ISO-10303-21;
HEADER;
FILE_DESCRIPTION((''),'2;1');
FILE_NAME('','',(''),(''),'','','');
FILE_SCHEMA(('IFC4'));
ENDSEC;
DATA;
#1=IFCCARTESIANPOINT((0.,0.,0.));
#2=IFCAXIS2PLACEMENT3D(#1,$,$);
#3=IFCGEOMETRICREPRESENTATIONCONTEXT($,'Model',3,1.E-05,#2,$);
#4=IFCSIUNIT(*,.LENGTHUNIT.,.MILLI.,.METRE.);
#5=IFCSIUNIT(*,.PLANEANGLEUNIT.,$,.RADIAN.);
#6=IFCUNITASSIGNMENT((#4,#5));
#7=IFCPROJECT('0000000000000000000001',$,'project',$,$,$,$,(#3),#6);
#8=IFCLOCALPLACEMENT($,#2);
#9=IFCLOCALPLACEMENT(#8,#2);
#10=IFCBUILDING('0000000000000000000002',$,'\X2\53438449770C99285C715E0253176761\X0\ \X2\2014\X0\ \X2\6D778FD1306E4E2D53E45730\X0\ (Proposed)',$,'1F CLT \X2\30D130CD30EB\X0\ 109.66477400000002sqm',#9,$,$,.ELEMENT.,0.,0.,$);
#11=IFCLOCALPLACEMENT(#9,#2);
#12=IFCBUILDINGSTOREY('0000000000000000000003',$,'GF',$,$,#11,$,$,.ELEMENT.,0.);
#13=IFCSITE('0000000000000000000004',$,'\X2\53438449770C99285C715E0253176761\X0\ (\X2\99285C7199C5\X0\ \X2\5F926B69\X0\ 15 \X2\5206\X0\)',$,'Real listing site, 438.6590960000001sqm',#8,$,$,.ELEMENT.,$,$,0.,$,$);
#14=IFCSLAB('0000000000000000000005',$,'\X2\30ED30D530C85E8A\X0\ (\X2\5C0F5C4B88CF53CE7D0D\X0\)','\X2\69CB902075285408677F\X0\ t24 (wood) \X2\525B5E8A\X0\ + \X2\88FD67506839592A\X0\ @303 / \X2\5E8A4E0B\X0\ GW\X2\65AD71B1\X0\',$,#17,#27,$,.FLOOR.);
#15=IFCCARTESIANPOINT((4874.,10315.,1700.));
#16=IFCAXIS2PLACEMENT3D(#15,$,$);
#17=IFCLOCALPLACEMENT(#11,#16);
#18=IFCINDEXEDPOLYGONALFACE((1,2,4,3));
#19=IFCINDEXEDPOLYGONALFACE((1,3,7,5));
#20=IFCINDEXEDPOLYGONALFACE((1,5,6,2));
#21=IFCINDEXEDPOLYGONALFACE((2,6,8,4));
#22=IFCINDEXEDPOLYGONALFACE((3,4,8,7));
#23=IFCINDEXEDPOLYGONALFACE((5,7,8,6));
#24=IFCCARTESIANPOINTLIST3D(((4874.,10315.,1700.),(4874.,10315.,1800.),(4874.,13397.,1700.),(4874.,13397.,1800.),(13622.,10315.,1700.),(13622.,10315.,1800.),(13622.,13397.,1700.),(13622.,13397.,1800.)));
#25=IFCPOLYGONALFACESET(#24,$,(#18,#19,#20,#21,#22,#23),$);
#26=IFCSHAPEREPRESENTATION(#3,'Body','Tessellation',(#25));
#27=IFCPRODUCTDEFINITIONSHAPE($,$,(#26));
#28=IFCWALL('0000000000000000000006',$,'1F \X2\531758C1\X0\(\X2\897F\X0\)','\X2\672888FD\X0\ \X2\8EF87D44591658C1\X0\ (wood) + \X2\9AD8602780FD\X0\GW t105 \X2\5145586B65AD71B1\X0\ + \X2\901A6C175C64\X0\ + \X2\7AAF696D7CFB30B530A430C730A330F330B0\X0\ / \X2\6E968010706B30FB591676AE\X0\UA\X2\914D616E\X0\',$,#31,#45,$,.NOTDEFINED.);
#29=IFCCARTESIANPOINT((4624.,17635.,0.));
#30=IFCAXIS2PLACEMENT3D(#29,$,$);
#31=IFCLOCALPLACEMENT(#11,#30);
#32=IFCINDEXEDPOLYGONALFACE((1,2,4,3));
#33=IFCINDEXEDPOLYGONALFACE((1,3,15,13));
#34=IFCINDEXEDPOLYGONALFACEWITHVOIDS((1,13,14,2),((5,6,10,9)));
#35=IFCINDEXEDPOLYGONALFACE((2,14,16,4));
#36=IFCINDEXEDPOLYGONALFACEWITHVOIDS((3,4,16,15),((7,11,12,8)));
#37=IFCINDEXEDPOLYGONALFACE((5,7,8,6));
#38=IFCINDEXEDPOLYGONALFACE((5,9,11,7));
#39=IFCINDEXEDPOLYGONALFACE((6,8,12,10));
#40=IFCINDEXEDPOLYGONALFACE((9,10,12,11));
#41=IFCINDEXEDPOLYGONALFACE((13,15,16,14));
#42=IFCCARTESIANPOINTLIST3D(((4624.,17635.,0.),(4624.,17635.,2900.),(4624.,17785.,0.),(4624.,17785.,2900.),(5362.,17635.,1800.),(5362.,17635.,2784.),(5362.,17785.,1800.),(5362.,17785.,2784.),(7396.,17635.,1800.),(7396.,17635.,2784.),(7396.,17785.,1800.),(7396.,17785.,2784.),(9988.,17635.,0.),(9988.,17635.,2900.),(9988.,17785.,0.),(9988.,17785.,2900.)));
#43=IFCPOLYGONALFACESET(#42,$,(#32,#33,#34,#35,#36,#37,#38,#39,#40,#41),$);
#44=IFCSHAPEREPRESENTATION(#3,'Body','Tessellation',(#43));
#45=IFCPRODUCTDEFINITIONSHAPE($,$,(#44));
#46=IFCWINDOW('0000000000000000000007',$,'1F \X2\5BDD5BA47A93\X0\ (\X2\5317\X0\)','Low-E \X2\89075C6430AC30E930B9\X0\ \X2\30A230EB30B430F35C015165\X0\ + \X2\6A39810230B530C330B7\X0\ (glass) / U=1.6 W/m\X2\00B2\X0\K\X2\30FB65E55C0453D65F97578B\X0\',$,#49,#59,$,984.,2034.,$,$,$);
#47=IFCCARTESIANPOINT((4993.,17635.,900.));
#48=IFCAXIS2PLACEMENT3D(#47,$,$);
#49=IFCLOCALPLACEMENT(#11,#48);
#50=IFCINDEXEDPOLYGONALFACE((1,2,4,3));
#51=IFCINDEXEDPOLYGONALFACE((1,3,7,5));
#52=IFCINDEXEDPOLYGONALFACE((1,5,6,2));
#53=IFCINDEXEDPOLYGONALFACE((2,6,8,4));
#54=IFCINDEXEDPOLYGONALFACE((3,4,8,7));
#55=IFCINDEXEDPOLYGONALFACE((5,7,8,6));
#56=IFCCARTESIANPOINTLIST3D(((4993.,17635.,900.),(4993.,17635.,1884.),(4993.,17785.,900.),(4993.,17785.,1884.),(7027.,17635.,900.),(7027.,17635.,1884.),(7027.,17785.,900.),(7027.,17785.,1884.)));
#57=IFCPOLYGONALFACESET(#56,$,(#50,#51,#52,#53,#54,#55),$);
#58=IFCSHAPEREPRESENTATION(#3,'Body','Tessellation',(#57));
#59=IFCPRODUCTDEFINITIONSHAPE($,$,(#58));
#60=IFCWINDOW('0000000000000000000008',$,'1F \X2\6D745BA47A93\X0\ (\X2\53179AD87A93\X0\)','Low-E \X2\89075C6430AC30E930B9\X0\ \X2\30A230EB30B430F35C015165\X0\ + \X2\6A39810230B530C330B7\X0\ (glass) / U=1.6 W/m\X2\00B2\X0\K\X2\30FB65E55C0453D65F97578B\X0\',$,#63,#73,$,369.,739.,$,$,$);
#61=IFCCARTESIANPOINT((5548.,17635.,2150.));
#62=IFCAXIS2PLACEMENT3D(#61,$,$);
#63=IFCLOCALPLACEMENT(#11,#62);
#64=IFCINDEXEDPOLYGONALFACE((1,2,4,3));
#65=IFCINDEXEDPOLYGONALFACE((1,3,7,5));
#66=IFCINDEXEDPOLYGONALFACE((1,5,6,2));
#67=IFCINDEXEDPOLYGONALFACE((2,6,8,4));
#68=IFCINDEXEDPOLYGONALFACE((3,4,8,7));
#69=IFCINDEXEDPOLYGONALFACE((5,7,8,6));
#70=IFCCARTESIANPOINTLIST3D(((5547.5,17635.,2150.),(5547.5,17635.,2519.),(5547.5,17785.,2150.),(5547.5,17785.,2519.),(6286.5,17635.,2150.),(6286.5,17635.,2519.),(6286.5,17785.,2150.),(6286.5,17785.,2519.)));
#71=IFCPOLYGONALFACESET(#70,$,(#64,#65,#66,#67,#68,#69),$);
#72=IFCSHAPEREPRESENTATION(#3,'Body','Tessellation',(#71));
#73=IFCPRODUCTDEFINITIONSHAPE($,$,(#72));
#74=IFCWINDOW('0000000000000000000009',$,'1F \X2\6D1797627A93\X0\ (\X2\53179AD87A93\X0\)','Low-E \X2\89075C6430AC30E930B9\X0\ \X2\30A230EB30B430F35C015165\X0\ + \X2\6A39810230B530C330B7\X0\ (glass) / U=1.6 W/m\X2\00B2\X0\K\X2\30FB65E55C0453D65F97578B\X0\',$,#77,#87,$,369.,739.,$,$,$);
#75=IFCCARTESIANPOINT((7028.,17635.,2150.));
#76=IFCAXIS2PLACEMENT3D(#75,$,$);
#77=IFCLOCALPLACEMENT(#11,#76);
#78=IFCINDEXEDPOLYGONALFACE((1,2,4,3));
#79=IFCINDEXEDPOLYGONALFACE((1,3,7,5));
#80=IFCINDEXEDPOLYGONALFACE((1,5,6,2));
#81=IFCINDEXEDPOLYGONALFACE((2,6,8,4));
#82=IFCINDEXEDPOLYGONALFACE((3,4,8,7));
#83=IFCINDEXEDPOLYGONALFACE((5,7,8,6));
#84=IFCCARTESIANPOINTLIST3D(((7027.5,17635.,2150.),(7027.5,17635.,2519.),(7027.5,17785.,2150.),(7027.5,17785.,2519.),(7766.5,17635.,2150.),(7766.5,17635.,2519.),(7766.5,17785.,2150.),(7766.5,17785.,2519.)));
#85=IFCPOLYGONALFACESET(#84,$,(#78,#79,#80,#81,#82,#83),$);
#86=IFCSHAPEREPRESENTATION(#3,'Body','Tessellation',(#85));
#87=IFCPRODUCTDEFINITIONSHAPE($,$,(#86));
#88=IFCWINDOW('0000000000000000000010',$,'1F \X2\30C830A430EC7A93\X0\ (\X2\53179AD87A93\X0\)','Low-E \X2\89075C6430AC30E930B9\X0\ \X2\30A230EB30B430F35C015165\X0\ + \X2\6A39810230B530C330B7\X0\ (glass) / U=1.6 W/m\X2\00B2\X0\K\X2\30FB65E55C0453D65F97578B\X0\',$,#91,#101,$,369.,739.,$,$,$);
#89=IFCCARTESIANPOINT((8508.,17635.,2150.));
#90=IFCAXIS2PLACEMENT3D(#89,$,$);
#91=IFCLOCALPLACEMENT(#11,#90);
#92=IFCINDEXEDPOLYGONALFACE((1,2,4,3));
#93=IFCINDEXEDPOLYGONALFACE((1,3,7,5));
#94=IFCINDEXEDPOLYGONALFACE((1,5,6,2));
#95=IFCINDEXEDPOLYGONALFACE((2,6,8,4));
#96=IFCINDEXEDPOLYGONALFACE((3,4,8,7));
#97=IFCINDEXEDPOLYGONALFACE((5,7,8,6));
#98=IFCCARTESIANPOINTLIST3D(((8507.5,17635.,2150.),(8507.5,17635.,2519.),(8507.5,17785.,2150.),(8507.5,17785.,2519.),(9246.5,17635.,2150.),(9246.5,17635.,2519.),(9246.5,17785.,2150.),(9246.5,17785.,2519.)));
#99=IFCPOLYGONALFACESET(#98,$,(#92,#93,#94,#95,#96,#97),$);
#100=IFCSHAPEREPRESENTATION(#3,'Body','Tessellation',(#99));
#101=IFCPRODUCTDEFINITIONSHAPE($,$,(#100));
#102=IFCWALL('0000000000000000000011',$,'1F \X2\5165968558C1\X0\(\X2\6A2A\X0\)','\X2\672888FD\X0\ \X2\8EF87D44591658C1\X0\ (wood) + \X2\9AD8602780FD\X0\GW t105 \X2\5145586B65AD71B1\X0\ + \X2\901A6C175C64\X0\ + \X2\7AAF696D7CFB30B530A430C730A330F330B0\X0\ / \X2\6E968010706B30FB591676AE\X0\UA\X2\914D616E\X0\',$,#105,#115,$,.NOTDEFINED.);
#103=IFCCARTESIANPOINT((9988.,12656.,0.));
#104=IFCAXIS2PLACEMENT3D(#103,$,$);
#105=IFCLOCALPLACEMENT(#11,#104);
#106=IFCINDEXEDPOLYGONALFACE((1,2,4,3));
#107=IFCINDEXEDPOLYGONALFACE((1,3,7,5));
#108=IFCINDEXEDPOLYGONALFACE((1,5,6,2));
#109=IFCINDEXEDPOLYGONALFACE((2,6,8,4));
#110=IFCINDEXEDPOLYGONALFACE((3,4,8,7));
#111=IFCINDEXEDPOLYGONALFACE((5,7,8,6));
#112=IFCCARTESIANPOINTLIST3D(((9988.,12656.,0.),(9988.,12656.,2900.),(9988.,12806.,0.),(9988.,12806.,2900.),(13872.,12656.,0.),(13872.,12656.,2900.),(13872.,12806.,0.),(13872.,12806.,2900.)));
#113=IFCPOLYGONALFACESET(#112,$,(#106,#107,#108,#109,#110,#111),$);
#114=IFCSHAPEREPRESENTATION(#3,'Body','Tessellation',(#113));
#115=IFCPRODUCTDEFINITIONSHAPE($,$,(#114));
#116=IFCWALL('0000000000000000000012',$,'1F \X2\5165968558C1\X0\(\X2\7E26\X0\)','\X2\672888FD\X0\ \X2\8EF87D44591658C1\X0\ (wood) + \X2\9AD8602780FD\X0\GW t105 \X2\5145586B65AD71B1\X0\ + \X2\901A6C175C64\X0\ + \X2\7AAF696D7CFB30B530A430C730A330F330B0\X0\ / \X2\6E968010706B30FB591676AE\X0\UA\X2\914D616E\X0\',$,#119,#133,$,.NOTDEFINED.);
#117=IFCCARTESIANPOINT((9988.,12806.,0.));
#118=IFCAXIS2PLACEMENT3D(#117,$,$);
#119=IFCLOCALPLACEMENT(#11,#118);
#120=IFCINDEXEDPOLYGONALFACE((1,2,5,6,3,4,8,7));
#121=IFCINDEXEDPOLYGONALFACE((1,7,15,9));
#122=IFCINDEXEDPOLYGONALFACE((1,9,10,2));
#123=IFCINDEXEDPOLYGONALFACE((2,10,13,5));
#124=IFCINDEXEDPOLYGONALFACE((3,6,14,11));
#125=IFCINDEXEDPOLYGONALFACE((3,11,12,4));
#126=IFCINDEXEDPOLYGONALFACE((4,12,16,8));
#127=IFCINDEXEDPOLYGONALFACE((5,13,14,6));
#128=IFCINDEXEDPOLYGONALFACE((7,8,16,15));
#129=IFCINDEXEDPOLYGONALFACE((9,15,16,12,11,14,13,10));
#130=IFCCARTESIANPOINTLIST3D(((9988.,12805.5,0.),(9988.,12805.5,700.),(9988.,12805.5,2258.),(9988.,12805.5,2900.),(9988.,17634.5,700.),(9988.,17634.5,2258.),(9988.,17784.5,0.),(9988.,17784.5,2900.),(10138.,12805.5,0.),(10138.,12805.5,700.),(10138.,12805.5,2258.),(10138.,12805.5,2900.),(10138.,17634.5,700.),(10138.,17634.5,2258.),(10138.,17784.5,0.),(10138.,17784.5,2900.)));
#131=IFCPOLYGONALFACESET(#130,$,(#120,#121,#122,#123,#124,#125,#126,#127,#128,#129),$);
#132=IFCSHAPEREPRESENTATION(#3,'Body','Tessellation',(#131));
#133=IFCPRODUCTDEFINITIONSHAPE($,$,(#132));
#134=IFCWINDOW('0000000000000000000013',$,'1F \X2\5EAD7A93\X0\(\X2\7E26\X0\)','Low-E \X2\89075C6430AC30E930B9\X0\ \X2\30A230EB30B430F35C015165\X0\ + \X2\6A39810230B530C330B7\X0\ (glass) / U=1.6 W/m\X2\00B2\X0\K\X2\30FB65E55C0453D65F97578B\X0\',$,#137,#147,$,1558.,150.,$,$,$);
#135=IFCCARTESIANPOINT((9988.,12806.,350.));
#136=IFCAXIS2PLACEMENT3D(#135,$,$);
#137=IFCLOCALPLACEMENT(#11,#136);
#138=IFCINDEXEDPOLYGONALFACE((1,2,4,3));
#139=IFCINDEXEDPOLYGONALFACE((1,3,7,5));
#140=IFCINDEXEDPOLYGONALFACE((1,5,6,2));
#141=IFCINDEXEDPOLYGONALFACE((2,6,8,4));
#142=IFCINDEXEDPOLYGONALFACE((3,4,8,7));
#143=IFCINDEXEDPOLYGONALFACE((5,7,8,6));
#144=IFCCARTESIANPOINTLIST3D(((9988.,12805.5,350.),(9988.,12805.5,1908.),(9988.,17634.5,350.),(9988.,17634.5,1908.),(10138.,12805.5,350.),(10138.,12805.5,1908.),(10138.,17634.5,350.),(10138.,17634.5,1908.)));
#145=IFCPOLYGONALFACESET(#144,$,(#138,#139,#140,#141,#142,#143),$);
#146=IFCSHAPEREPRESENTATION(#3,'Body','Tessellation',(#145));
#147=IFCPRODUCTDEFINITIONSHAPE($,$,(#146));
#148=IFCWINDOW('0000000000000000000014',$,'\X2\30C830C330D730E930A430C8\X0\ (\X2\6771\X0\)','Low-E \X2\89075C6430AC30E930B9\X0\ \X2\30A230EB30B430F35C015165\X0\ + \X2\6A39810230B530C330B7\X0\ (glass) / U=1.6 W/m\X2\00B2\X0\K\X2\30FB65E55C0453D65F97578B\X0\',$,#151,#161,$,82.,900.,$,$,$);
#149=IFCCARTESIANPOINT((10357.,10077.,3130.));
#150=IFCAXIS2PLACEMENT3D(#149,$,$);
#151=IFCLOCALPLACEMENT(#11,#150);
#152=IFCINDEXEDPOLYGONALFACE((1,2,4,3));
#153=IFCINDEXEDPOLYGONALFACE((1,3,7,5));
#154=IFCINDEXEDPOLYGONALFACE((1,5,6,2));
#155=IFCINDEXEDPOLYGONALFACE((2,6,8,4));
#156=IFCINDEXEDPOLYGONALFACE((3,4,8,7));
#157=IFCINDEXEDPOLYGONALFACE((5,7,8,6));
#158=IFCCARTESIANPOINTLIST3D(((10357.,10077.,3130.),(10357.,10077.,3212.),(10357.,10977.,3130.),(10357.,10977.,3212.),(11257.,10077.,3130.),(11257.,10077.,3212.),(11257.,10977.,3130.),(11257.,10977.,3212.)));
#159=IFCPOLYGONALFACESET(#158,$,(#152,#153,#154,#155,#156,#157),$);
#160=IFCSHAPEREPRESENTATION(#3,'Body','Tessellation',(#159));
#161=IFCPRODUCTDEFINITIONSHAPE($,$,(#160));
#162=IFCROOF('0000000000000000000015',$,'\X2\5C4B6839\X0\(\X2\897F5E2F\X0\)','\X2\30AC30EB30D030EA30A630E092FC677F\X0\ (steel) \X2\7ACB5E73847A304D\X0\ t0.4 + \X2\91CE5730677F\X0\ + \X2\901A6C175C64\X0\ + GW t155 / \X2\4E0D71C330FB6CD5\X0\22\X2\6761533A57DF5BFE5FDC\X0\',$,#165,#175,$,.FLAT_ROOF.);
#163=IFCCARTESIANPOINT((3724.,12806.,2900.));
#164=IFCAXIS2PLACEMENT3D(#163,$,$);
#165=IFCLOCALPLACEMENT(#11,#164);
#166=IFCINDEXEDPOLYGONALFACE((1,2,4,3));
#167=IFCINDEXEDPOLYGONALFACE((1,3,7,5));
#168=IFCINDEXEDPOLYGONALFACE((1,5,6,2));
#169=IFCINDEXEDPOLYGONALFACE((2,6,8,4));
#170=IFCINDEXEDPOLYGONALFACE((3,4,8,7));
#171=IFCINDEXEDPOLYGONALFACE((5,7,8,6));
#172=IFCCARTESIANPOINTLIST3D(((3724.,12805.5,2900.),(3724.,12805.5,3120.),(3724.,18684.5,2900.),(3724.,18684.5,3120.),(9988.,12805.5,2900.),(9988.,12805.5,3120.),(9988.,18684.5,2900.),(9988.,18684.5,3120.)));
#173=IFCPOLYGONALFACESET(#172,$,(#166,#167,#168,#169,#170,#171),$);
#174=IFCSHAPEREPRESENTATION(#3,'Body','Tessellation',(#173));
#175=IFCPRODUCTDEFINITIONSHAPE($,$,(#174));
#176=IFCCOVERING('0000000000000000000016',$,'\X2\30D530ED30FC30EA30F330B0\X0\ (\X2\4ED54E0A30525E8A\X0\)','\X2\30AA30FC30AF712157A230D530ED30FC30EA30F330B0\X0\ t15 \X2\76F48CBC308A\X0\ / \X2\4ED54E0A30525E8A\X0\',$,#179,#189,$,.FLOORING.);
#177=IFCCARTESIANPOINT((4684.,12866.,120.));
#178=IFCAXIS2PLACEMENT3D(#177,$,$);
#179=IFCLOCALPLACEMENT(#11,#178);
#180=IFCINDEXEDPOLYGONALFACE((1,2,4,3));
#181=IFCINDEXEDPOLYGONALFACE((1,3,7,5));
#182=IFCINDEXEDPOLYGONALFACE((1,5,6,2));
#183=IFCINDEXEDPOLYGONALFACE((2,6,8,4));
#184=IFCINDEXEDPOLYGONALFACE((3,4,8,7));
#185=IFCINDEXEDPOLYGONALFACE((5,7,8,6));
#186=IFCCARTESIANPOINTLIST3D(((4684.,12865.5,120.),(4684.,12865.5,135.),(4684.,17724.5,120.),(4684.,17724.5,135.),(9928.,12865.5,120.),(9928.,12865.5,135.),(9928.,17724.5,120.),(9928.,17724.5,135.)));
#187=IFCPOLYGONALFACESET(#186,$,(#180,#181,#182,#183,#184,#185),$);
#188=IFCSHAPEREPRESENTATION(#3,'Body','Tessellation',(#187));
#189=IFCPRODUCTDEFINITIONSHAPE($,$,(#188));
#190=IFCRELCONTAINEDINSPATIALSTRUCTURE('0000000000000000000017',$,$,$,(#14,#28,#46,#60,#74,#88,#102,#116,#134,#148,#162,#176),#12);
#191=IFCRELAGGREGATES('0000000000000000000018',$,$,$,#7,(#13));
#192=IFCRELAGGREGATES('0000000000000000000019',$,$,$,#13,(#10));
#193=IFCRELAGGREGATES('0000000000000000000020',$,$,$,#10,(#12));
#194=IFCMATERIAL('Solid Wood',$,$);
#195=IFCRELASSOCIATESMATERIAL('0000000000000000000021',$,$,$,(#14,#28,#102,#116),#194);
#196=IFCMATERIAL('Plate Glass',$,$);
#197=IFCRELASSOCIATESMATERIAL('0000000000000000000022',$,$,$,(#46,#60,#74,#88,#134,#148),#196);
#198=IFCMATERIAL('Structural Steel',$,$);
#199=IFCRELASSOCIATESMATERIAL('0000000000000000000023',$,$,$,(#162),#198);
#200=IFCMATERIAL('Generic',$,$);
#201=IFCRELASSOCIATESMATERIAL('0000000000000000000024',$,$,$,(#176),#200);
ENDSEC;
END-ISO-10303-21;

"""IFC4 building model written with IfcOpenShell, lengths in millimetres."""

from ifc_helpers import new_model, si_unit, frame, frame_2d, origin, place, context, project, spatial, rectangle, extrude, material, element, fill, save


model = new_model("IFC4")

# Units and contexts
model_context = context("Model", 3, precision=1e-05, world=origin())
ifc_project = project(units=[si_unit("LENGTHUNIT", "METRE", prefix="MILLI"), si_unit("PLANEANGLEUNIT", "RADIAN")], contexts=[model_context])

# Site, building, storey
site_placement = place(None, origin())
site = spatial("IfcSite", under=ifc_project, at=site_placement, Name="千葉県館山市北条 (館山駅 徒歩 15 分)", ObjectType="Real listing site, 438.6590960000001sqm", CompositionType="ELEMENT", RefElevation=0.0)
building_placement = place(site_placement, origin())
building = spatial("IfcBuilding", under=site, at=building_placement, Name="千葉県館山市北条 — 海近の中古地 (Proposed)", ObjectType="1F CLT パネル 109.66477400000002sqm", CompositionType="ELEMENT", ElevationOfRefHeight=0.0, ElevationOfTerrain=0.0)
storey_placement = place(building_placement, origin())
storey = spatial("IfcBuildingStorey", under=building, at=storey_placement, Name="GF", CompositionType="ELEMENT", Elevation=0.0)

# Slab
ifc_material_1 = material(Name="Solid Wood")
slab_1_placement = place(storey_placement, frame((4874.0, 10315.0, 1700.0)))
element("IfcSlab", 1, at=slab_1_placement, inside=storey, material=ifc_material_1, Name="ロフト床 (小屋裏収納)", Description="構造用合板 t24 (wood) 剛床 + 製材根太 @303 / 床下 GW断熱", PredefinedType="FLOOR", context=model_context, shape_type="SweptSolid", body=[
    extrude(rectangle(XDim=8748.0, YDim=3082.0, at=frame_2d((4374.0, 1541.0))), frame((4874.0, 10315.0, 1700.0)), (0.0, 0.0, 1.0), 100.0),
])

# Wall, openings, windows
wall_1_placement = place(storey_placement, frame((4624.0, 17635.0, 0.0)))
wall_1 = element("IfcWall", 2, at=wall_1_placement, inside=storey, material=ifc_material_1, Name="1F 北壁(西)", Description="木製 軸組外壁 (wood) + 高性能GW t105 充填断熱 + 通気層 + 窯業系サイディング / 準耐火・外皮UA配慮", PredefinedType="NOTDEFINED", context=model_context, shape_type="SweptSolid", body=[
    extrude(rectangle(XDim=5364.0, YDim=150.0, at=frame_2d((2682.0, 75.0))), frame((4624.0, 17635.0, 0.0)), (0.0, 0.0, 1.0), 2900.0),
])
opening_1_placement = place(storey_placement, frame((4993.0, 17635.0, 900.0)))
opening_1 = element("IfcOpeningElement", 3, at=opening_1_placement, cuts=wall_1, PredefinedType="NOTDEFINED", context=model_context, shape_type="SweptSolid", body=[
    extrude(rectangle(XDim=2034.0, YDim=150.0, at=frame_2d((1017.0, 75.0))), frame((4993.0, 17635.0, 900.0)), (0.0, 0.0, 1.0), 984.0),
])
opening_2_placement = place(storey_placement, frame((5548.0, 17635.0, 2150.0)))
opening_2 = element("IfcOpeningElement", 4, at=opening_2_placement, cuts=wall_1, PredefinedType="NOTDEFINED", context=model_context, shape_type="SweptSolid", body=[
    extrude(rectangle(XDim=739.0, YDim=150.0, at=frame_2d((369.0, 75.0))), frame((5548.0, 17635.0, 2150.0)), (0.0, 0.0, 1.0), 369.0),
])
opening_3_placement = place(storey_placement, frame((7028.0, 17635.0, 2150.0)))
opening_3 = element("IfcOpeningElement", 5, at=opening_3_placement, cuts=wall_1, PredefinedType="NOTDEFINED", context=model_context, shape_type="SweptSolid", body=[
    extrude(rectangle(XDim=739.0, YDim=150.0, at=frame_2d((369.0, 75.0))), frame((7028.0, 17635.0, 2150.0)), (0.0, 0.0, 1.0), 369.0),
])
opening_4_placement = place(storey_placement, frame((8508.0, 17635.0, 2150.0)))
opening_4 = element("IfcOpeningElement", 6, at=opening_4_placement, cuts=wall_1, PredefinedType="NOTDEFINED", context=model_context, shape_type="SweptSolid", body=[
    extrude(rectangle(XDim=739.0, YDim=150.0, at=frame_2d((369.0, 75.0))), frame((8508.0, 17635.0, 2150.0)), (0.0, 0.0, 1.0), 369.0),
])
ifc_material_2 = material(Name="Plate Glass")
window_1_placement = place(storey_placement, frame((4993.0, 17635.0, 900.0)))
window_1 = element("IfcWindow", 7, at=window_1_placement, inside=storey, material=ifc_material_2, Name="1F 寝室窓 (北)", Description="Low-E 複層ガラス アルゴン封入 + 樹脂サッシ (glass) / U=1.6 W/m²K・日射取得型", OverallHeight=984.0, OverallWidth=2034.0, context=model_context, shape_type="SweptSolid", body=[
    extrude(rectangle(XDim=2034.0, YDim=150.0, at=frame_2d((1017.0, 75.0))), frame((4993.0, 17635.0, 900.0)), (0.0, 0.0, 1.0), 984.0),
])
fill(opening_1, window_1)
window_2_placement = place(storey_placement, frame((5548.0, 17635.0, 2150.0)))
window_2 = element("IfcWindow", 8, at=window_2_placement, inside=storey, material=ifc_material_2, Name="1F 浴室窓 (北高窓)", Description="Low-E 複層ガラス アルゴン封入 + 樹脂サッシ (glass) / U=1.6 W/m²K・日射取得型", OverallHeight=369.0, OverallWidth=739.0, context=model_context, shape_type="SweptSolid", body=[
    extrude(rectangle(XDim=739.0, YDim=150.0, at=frame_2d((369.0, 75.0))), frame((5548.0, 17635.0, 2150.0)), (0.0, 0.0, 1.0), 369.0),
])
fill(opening_2, window_2)
window_3_placement = place(storey_placement, frame((7028.0, 17635.0, 2150.0)))
window_3 = element("IfcWindow", 9, at=window_3_placement, inside=storey, material=ifc_material_2, Name="1F 洗面窓 (北高窓)", Description="Low-E 複層ガラス アルゴン封入 + 樹脂サッシ (glass) / U=1.6 W/m²K・日射取得型", OverallHeight=369.0, OverallWidth=739.0, context=model_context, shape_type="SweptSolid", body=[
    extrude(rectangle(XDim=739.0, YDim=150.0, at=frame_2d((369.0, 75.0))), frame((7028.0, 17635.0, 2150.0)), (0.0, 0.0, 1.0), 369.0),
])
fill(opening_3, window_3)
window_4_placement = place(storey_placement, frame((8508.0, 17635.0, 2150.0)))
window_4 = element("IfcWindow", 10, at=window_4_placement, inside=storey, material=ifc_material_2, Name="1F トイレ窓 (北高窓)", Description="Low-E 複層ガラス アルゴン封入 + 樹脂サッシ (glass) / U=1.6 W/m²K・日射取得型", OverallHeight=369.0, OverallWidth=739.0, context=model_context, shape_type="SweptSolid", body=[
    extrude(rectangle(XDim=739.0, YDim=150.0, at=frame_2d((369.0, 75.0))), frame((8508.0, 17635.0, 2150.0)), (0.0, 0.0, 1.0), 369.0),
])
fill(opening_4, window_4)

# Wall
wall_2_placement = place(storey_placement, frame((9988.0, 12656.0, 0.0)))
element("IfcWall", 11, at=wall_2_placement, inside=storey, material=ifc_material_1, Name="1F 入隅壁(横)", Description="木製 軸組外壁 (wood) + 高性能GW t105 充填断熱 + 通気層 + 窯業系サイディング / 準耐火・外皮UA配慮", PredefinedType="NOTDEFINED", context=model_context, shape_type="SweptSolid", body=[
    extrude(rectangle(XDim=3884.0, YDim=150.0, at=frame_2d((1942.0, 75.0))), frame((9988.0, 12656.0, 0.0)), (0.0, 0.0, 1.0), 2900.0),
])

# Wall, opening, window
wall_3_placement = place(storey_placement, frame((9988.0, 12806.0, 0.0)))
wall_3 = element("IfcWall", 12, at=wall_3_placement, inside=storey, material=ifc_material_1, Name="1F 入隅壁(縦)", Description="木製 軸組外壁 (wood) + 高性能GW t105 充填断熱 + 通気層 + 窯業系サイディング / 準耐火・外皮UA配慮", PredefinedType="NOTDEFINED", context=model_context, shape_type="SweptSolid", body=[
    extrude(rectangle(XDim=150.0, YDim=4979.0, at=frame_2d((75.0, 2489.0))), frame((9988.0, 12806.0, 0.0)), (0.0, 0.0, 1.0), 2900.0),
])
opening_5_placement = place(storey_placement, frame((9988.0, 12806.0, 350.0)))
opening_5 = element("IfcOpeningElement", 13, at=opening_5_placement, cuts=wall_3, PredefinedType="NOTDEFINED", context=model_context, shape_type="SweptSolid", body=[
    extrude(rectangle(XDim=150.0, YDim=4829.0, at=frame_2d((75.0, 2414.0))), frame((9988.0, 12806.0, 350.0)), (0.0, 0.0, 1.0), 1558.0),
])
window_5_placement = place(storey_placement, frame((9988.0, 12806.0, 350.0)))
window_5 = element("IfcWindow", 14, at=window_5_placement, inside=storey, material=ifc_material_2, Name="1F 庭窓(縦)", Description="Low-E 複層ガラス アルゴン封入 + 樹脂サッシ (glass) / U=1.6 W/m²K・日射取得型", OverallHeight=1558.0, OverallWidth=150.0, context=model_context, shape_type="SweptSolid", body=[
    extrude(rectangle(XDim=150.0, YDim=4829.0, at=frame_2d((75.0, 2414.0))), frame((9988.0, 12806.0, 350.0)), (0.0, 0.0, 1.0), 1558.0),
])
fill(opening_5, window_5)

# Window
window_6_placement = place(storey_placement, frame((10357.0, 10077.0, 3130.0)))
element("IfcWindow", 15, at=window_6_placement, inside=storey, material=ifc_material_2, Name="トップライト (東)", Description="Low-E 複層ガラス アルゴン封入 + 樹脂サッシ (glass) / U=1.6 W/m²K・日射取得型", OverallHeight=82.0, OverallWidth=900.0, context=model_context, shape_type="SweptSolid", body=[
    extrude(rectangle(XDim=900.0, YDim=900.0, at=frame_2d((450.0, 450.0))), frame((10357.0, 10077.0, 3130.0)), (0.0, 0.0, 1.0), 82.0),
])

# Roof
ifc_material_3 = material(Name="Structural Steel")
roof_placement = place(storey_placement, frame((3724.0, 12806.0, 2900.0)))
element("IfcRoof", 16, at=roof_placement, inside=storey, material=ifc_material_3, Name="屋根(西帯)", Description="ガルバリウム鋼板 (steel) 立平葺き t0.4 + 野地板 + 通気層 + GW t155 / 不燃・法22条区域対応", PredefinedType="FLAT_ROOF", context=model_context, shape_type="SweptSolid", body=[
    extrude(rectangle(XDim=6264.0, YDim=5879.0, at=frame_2d((3132.0, 2939.0))), frame((3724.0, 12806.0, 2900.0)), (0.0, 0.0, 1.0), 220.0),
])

# Covering
ifc_material_4 = material(Name="Generic")
covering_placement = place(storey_placement, frame((4684.0, 12866.0, 120.0)))
element("IfcCovering", 17, at=covering_placement, inside=storey, material=ifc_material_4, Name="フローリング (仕上げ床)", Description="オーク無垢フローリング t15 直貼り / 仕上げ床", PredefinedType="FLOORING", context=model_context, shape_type="SweptSolid", body=[
    extrude(rectangle(XDim=5244.0, YDim=4859.0, at=frame_2d((2622.0, 2429.0))), frame((4684.0, 12866.0, 120.0)), (0.0, 0.0, 1.0), 15.0),
])

save(model, "model.ifc")
